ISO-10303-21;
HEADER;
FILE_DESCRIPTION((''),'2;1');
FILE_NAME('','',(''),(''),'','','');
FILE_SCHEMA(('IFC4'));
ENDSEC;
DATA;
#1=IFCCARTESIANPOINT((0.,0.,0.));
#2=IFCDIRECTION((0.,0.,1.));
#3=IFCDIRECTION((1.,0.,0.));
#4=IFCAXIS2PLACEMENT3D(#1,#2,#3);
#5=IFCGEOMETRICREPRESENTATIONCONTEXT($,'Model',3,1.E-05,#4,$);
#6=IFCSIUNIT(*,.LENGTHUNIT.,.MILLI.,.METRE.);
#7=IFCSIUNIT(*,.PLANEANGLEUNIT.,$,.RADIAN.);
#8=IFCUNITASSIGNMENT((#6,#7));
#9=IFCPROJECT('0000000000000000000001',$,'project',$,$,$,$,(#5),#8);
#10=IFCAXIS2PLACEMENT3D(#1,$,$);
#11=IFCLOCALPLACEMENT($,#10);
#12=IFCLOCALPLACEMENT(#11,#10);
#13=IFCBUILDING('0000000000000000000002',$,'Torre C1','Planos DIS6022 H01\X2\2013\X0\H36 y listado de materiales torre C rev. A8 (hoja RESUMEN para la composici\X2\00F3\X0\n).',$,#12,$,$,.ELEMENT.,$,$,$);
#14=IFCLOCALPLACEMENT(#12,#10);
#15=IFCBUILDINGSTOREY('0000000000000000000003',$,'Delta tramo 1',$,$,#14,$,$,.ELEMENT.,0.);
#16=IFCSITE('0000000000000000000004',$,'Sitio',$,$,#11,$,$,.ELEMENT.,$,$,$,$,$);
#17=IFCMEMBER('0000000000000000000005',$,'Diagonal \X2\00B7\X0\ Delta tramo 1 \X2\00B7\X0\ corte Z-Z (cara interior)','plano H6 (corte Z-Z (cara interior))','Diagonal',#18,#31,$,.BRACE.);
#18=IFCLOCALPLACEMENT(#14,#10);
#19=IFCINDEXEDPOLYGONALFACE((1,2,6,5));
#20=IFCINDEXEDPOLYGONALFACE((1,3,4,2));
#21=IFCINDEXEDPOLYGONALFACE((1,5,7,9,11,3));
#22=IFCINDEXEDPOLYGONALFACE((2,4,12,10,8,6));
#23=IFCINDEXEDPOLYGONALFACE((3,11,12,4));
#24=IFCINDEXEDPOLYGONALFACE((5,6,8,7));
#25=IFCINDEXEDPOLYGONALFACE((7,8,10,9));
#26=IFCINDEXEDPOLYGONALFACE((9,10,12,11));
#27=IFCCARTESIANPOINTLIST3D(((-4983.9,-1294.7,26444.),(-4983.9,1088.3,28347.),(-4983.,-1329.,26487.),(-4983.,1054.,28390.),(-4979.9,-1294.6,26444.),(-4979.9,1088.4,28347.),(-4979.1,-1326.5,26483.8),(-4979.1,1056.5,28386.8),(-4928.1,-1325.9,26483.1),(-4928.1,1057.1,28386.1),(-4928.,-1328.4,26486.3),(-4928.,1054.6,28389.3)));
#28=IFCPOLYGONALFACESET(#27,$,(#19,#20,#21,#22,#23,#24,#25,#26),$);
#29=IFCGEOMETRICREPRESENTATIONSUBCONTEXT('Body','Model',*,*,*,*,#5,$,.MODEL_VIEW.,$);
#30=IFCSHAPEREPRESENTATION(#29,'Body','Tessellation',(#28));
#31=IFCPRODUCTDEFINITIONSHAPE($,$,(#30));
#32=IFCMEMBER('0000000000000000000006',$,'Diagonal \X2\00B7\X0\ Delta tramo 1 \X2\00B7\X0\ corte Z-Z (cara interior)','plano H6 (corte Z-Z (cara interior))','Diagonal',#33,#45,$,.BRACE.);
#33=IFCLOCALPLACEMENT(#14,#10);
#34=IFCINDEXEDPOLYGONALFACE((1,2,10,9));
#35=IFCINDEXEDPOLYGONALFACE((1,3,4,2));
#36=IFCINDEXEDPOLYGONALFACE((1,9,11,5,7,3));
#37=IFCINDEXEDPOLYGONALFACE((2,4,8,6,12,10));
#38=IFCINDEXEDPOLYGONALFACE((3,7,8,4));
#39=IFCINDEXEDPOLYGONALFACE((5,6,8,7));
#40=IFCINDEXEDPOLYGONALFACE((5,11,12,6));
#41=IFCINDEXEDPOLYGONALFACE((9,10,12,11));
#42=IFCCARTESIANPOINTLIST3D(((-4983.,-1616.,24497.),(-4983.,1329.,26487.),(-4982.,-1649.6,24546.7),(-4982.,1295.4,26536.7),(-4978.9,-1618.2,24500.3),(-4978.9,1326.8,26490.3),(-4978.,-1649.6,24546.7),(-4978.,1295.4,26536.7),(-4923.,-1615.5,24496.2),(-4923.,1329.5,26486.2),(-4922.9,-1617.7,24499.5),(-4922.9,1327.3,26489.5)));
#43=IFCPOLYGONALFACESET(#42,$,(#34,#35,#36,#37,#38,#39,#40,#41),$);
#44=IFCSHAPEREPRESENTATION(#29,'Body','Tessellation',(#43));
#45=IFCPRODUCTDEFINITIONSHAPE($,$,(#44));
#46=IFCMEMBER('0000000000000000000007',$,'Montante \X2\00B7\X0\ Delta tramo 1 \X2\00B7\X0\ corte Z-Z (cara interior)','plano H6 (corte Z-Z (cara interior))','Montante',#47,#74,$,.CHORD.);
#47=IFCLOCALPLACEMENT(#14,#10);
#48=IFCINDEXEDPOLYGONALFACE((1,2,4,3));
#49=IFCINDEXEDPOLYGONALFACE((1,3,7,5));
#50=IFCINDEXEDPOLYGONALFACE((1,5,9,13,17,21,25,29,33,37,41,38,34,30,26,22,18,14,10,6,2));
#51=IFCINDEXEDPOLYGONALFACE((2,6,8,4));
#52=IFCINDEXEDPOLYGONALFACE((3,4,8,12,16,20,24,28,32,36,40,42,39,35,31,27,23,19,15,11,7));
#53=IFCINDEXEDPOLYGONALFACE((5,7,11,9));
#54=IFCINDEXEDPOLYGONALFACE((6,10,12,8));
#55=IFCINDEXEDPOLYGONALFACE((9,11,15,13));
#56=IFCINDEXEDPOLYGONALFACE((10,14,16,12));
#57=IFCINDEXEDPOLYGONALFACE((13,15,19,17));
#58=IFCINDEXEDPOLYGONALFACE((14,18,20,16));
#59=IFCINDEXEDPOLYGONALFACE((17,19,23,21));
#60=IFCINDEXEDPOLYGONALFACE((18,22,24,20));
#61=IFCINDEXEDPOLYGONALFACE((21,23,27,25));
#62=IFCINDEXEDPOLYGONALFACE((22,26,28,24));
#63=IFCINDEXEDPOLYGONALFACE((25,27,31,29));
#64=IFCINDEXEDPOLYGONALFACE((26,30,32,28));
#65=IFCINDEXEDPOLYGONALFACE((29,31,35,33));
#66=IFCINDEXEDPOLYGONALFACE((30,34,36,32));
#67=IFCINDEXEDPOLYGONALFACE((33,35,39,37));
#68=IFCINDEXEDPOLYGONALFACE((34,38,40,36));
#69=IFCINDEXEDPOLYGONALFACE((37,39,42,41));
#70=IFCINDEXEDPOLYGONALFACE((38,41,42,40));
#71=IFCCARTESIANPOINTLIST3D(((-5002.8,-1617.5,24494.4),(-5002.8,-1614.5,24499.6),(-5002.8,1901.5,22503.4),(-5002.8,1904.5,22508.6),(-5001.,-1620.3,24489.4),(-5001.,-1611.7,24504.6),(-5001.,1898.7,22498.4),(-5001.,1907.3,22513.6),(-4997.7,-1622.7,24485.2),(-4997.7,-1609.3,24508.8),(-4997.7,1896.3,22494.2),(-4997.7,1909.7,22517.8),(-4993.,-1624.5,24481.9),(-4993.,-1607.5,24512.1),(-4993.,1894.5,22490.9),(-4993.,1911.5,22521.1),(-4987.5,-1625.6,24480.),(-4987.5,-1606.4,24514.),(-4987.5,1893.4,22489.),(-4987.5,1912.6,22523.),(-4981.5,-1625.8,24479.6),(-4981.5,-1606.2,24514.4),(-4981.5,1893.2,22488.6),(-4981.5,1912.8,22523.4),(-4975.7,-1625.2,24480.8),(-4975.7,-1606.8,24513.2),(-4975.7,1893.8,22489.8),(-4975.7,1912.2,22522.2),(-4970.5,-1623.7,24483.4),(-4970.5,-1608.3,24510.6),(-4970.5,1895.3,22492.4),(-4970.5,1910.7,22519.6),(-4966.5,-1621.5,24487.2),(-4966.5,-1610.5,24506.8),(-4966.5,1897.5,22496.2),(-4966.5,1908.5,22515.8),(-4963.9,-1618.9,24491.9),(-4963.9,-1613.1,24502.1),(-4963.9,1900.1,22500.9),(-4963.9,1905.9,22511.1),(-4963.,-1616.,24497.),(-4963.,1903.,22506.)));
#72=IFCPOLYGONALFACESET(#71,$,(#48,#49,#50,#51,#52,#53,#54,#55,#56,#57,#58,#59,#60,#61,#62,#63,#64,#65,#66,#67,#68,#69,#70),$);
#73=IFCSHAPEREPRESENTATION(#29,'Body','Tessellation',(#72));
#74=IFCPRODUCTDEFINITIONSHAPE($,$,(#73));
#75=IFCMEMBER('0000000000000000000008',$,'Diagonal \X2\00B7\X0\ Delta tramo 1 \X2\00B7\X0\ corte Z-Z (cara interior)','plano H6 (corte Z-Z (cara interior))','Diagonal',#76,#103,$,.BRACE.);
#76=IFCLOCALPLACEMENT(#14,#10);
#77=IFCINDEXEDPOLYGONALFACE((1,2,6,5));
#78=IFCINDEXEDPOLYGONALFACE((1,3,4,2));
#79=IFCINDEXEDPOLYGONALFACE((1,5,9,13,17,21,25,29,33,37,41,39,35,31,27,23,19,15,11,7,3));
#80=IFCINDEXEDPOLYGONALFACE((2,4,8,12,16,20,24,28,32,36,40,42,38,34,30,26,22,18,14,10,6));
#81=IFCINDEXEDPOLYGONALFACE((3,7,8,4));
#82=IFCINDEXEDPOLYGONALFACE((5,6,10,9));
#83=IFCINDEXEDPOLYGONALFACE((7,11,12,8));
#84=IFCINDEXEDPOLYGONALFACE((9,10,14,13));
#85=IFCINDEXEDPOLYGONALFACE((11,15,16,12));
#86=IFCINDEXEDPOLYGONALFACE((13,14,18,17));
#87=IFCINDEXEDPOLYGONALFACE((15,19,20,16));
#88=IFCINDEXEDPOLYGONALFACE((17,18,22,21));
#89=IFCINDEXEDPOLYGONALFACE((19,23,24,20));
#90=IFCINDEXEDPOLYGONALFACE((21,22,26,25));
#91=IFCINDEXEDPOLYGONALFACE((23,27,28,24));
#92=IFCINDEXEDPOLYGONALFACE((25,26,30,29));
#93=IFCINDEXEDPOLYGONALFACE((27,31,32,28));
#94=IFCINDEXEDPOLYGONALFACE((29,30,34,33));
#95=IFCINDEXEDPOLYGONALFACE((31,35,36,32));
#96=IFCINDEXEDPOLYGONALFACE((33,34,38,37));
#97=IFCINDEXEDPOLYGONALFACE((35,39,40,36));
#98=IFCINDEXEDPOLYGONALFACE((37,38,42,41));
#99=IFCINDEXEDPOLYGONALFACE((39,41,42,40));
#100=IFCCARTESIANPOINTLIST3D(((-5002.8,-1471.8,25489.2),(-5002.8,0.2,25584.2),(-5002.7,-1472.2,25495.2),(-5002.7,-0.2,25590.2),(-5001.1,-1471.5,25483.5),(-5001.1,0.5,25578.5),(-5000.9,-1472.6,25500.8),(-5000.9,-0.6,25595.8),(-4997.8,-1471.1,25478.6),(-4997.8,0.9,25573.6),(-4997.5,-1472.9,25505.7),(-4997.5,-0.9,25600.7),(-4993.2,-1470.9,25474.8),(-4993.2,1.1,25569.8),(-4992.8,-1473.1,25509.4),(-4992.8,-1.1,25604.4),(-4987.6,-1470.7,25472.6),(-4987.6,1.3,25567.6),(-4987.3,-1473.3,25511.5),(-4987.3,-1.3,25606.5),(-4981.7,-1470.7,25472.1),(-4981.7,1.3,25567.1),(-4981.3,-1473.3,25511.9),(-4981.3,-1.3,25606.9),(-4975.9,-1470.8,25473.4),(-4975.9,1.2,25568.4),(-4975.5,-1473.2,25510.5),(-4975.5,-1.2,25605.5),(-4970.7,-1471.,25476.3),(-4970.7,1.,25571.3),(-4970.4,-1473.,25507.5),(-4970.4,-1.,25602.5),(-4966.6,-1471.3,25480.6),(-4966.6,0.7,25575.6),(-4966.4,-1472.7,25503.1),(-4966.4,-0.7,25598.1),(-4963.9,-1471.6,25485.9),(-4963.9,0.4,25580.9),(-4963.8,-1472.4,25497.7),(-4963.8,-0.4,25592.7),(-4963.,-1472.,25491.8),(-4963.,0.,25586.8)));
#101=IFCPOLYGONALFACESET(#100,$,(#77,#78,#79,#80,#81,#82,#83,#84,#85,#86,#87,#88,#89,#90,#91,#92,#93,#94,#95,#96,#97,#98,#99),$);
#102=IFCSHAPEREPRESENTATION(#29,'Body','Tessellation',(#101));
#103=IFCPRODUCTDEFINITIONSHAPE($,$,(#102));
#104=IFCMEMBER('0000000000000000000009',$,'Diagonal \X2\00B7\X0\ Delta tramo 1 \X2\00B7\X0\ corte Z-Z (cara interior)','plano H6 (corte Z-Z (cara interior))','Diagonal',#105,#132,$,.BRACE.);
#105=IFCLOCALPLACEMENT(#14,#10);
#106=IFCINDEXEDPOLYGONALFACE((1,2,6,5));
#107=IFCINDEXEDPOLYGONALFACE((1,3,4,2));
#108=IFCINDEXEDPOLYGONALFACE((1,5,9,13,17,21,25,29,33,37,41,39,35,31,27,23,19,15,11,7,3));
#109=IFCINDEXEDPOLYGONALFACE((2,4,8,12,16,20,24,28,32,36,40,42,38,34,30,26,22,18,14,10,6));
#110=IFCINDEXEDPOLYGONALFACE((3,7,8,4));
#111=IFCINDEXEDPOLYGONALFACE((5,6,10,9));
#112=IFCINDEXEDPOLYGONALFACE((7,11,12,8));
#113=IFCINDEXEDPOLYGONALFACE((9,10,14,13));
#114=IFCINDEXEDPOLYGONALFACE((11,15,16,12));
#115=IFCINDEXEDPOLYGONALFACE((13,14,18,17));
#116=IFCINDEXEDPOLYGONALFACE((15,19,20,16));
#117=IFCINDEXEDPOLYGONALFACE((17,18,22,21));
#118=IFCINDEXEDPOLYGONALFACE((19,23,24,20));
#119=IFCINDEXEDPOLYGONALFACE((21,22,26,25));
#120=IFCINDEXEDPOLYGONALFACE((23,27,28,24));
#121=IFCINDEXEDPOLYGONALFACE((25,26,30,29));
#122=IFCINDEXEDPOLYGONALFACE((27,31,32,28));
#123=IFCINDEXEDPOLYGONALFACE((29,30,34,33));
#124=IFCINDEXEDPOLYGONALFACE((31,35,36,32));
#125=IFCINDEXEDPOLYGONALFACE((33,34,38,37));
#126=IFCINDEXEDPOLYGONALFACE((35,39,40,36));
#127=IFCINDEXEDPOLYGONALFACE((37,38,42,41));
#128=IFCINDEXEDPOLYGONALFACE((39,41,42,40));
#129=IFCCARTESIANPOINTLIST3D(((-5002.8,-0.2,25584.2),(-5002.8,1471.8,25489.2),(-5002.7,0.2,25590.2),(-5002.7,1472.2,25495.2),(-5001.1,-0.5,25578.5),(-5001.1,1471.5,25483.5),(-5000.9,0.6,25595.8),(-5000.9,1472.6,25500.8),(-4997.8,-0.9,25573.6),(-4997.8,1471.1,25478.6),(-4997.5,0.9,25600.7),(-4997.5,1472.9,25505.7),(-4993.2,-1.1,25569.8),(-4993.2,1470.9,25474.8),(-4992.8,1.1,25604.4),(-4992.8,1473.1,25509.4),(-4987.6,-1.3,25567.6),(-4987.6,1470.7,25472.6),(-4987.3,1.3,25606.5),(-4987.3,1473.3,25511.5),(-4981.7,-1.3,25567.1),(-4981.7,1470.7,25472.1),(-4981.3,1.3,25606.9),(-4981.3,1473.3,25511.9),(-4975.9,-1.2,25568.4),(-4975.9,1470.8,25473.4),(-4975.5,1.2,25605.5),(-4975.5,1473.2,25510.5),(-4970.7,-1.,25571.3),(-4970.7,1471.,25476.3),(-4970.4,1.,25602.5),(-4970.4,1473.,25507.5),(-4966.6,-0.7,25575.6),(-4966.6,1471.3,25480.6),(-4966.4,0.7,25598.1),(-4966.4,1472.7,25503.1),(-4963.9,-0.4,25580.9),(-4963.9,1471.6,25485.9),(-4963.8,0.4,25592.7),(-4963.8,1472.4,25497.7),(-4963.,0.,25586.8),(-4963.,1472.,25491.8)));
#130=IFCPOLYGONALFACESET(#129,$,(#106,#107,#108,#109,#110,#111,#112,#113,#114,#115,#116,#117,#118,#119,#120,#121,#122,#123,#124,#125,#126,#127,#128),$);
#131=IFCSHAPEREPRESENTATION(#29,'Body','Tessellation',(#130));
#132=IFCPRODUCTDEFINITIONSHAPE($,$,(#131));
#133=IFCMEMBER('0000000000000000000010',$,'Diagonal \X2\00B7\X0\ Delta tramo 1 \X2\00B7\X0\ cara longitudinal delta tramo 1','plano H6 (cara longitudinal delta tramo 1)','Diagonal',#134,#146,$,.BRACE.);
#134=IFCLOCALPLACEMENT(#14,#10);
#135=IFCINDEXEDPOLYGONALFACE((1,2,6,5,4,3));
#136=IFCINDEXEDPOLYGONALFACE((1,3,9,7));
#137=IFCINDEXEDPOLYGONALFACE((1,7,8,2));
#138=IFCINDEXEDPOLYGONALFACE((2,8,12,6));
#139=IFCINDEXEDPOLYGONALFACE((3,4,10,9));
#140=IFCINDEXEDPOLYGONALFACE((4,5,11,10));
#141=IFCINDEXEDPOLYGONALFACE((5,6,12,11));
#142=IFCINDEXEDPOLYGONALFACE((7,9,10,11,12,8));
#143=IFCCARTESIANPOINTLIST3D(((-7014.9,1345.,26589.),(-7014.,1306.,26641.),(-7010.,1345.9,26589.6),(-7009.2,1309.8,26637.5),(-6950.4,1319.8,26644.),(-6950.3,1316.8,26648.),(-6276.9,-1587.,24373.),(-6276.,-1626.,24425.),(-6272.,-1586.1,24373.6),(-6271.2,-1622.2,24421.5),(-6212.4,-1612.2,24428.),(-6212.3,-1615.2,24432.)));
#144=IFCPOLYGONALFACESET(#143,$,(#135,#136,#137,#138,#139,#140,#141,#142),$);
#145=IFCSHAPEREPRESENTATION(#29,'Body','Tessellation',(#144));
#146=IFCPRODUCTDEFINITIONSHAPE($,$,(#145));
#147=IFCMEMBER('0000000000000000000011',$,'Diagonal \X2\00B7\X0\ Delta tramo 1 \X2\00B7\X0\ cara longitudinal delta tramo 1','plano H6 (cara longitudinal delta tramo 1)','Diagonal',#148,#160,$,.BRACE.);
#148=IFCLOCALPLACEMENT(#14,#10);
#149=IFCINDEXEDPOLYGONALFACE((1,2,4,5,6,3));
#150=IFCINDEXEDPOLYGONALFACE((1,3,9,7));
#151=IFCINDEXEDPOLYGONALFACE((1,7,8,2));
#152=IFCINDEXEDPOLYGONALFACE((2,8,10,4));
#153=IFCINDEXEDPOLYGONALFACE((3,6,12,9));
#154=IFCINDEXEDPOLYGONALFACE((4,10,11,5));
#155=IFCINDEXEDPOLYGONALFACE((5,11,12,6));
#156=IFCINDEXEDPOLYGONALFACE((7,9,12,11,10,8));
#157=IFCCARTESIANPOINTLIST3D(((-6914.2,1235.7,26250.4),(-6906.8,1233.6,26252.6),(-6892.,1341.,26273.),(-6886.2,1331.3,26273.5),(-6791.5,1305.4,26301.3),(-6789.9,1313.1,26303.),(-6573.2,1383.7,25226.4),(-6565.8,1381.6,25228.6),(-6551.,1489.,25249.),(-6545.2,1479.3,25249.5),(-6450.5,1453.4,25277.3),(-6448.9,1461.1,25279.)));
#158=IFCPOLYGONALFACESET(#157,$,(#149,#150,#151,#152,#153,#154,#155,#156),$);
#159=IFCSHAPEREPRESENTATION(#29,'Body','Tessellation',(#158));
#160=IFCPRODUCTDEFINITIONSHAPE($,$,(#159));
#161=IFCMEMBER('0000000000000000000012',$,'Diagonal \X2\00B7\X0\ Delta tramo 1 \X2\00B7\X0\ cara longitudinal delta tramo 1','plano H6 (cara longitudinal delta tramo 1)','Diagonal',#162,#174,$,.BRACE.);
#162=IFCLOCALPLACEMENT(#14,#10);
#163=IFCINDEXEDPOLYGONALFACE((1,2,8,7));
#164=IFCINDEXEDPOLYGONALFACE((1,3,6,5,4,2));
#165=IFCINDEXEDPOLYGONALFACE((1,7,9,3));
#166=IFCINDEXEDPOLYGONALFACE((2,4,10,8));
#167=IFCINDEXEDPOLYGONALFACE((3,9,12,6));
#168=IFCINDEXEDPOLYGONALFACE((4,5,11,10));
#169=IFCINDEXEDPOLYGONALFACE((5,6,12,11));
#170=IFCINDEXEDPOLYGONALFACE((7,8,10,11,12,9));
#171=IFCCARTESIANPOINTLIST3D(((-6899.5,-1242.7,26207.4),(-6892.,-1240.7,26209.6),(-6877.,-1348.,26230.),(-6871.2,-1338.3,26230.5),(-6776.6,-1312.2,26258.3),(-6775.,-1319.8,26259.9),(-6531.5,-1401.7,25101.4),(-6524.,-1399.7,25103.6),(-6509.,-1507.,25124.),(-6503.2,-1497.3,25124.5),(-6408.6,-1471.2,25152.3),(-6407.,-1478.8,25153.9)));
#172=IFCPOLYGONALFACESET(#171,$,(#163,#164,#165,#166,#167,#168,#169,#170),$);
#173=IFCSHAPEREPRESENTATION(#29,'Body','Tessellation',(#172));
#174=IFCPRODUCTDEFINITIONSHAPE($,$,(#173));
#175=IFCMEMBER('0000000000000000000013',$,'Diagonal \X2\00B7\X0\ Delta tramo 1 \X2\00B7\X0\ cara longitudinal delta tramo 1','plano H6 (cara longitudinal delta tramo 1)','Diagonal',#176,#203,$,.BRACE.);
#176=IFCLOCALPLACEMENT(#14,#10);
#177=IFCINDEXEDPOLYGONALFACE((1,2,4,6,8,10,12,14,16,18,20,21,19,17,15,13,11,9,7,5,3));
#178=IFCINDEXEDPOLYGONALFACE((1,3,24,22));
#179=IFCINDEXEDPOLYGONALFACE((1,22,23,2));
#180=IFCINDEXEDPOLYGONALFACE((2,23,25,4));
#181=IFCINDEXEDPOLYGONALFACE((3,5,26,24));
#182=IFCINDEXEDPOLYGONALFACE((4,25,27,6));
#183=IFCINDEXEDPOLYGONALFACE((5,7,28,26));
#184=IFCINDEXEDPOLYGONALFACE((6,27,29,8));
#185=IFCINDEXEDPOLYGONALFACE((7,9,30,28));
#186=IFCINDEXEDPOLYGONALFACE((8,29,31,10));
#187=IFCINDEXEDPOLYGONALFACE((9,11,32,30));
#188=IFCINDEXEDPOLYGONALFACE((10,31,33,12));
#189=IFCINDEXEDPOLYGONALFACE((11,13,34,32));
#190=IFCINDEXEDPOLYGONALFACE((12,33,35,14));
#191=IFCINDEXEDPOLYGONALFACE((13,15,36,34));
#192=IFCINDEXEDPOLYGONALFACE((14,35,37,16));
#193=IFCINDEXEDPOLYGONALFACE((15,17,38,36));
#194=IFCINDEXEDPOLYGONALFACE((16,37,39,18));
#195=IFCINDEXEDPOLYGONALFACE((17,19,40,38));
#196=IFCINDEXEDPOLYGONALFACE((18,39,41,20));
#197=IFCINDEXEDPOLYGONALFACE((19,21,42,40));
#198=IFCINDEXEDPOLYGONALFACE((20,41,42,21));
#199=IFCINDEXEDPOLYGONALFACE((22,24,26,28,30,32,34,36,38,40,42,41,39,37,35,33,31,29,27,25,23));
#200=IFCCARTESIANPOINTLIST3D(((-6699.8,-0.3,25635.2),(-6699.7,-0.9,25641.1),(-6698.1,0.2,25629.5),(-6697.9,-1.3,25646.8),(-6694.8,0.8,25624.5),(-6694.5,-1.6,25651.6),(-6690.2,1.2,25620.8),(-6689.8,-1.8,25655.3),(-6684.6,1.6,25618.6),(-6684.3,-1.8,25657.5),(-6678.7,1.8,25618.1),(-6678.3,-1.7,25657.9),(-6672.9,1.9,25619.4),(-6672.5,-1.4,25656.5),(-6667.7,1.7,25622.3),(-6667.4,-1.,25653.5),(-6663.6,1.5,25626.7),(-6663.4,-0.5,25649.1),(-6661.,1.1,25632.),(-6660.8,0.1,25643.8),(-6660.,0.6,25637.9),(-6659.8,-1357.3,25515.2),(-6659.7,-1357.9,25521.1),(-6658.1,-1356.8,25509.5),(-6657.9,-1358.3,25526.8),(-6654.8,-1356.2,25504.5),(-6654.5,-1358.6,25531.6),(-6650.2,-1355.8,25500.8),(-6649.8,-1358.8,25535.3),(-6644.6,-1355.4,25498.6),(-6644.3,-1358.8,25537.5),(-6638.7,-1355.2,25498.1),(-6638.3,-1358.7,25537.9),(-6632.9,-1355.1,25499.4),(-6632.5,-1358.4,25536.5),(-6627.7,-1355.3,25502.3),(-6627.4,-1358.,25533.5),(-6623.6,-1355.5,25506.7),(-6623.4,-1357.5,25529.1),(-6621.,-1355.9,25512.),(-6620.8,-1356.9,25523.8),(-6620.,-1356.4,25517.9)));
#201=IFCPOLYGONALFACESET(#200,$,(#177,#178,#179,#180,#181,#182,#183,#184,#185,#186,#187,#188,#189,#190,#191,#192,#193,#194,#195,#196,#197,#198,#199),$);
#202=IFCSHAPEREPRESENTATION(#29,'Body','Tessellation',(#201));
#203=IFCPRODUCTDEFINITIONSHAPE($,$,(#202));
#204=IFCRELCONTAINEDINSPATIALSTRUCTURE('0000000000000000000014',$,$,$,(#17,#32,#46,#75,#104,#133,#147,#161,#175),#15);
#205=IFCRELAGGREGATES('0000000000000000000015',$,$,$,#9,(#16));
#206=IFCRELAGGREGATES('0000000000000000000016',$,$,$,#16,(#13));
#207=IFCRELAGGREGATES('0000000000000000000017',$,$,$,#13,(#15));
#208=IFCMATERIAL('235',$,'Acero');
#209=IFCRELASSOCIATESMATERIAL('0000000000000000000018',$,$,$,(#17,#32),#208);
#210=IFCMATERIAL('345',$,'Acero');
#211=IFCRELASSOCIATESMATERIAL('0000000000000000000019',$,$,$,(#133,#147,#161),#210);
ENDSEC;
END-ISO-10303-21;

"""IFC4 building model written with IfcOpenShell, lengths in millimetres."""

from ifc_helpers import new_model, si_unit, frame, frame_2d, origin, origin_with_axes, place, context, subcontext, project, spatial, circle, l_section, extrude, material, element, save


model = new_model("IFC4")

# Units and contexts
model_context = context("Model", 3, precision=1e-05, world=origin_with_axes())
body_context = subcontext(model_context, "Body", "Model", "MODEL_VIEW")
ifc_project = project(units=[si_unit("LENGTHUNIT", "METRE", prefix="MILLI"), si_unit("PLANEANGLEUNIT", "RADIAN")], contexts=[model_context])

# Site, building, storey
site_placement = place(None, origin())
site = spatial("IfcSite", under=ifc_project, at=site_placement, Name="Sitio", CompositionType="ELEMENT")
building_placement = place(site_placement, origin())
building = spatial("IfcBuilding", under=site, at=building_placement, Name="Torre C1", Description="Planos DIS6022 H01–H36 y listado de materiales torre C rev. A8 (hoja RESUMEN para la composición).", CompositionType="ELEMENT")
storey_placement = place(building_placement, origin())
storey = spatial("IfcBuildingStorey", under=building, at=storey_placement, Name="Delta tramo 1", CompositionType="ELEMENT", Elevation=0.0)

# Members
ifc_material_1 = material(Name="345", Category="Acero")
ifc_material_2 = material(Name="235", Category="Acero")
member_1_placement = place(storey_placement, frame((-4983.0, -1329.0, 26487.0), z_axis=(0.0, 0.781412, 0.624015), x_axis=(0.999852, 0.010743, -0.013453)))
element("IfcMember", 1, at=member_1_placement, inside=storey, material=ifc_material_2, Name="Diagonal · Delta tramo 1 · corte Z-Z (cara interior)", Description="plano H6 (corte Z-Z (cara interior))", ObjectType="Diagonal", PredefinedType="BRACE", context=body_context, shape_type="SweptSolid", body=[
    extrude(l_section(Depth=55.0, Width=55.0, Thickness=4.0, at=frame_2d((27.5, 27.5))), None, (0.0, 0.0, 1.0), 3049.6),
])
member_2_placement = place(storey_placement, frame((-4983.0, 1329.0, 26487.0), z_axis=(0.0, -0.828571, -0.559884), x_axis=(0.99987, 0.009026, -0.013358)))
element("IfcMember", 2, at=member_2_placement, inside=storey, material=ifc_material_2, Name="Diagonal · Delta tramo 1 · corte Z-Z (cara interior)", Description="plano H6 (corte Z-Z (cara interior))", ObjectType="Diagonal", PredefinedType="BRACE", context=body_context, shape_type="SweptSolid", body=[
    extrude(l_section(Depth=60.0, Width=60.0, Thickness=4.0, at=frame_2d((30.0, 30.0))), None, (0.0, 0.0, 1.0), 3554.3),
])
member_3_placement = place(storey_placement, frame((-4983.0, -1616.0, 24497.0), z_axis=(0.0, 0.870351, -0.492432), x_axis=(1.0, 0.0, 0.0)))
element("IfcMember", 3, at=member_3_placement, inside=storey, Name="Montante · Delta tramo 1 · corte Z-Z (cara interior)", Description="plano H6 (corte Z-Z (cara interior))", ObjectType="Montante", PredefinedType="CHORD", context=body_context, shape_type="SweptSolid", body=[
    extrude(circle(Radius=20.0), None, (0.0, 0.0, 1.0), 4043.2),
])
for number, where, z_axis, x_axis, name in (
    (4, (-4983.0, -1472.0, 25492.0), (0.0, 0.997924, 0.064404), (0.999955, 0.000613, -0.009492), "Diagonal · Delta tramo 1 · corte Z-Z (cara interior)"),
    (5, (-4983.0, 1472.0, 25492.0), (0.0, -0.997924, 0.064404), (0.999955, -0.000613, -0.009492), "Diagonal · Delta tramo 1 · corte Z-Z (cara interior)"),
):
    element("IfcMember", number, at=place(storey_placement, frame(where, z_axis=z_axis, x_axis=x_axis)), inside=storey, Name=name, Description="plano H6 (corte Z-Z (cara interior))", ObjectType="Diagonal", PredefinedType="BRACE", context=body_context, shape_type="SweptSolid", body=[
        extrude(circle(Radius=20.0), None, (0.0, 0.0, 1.0), 1475.1),
    ])
member_4_placement = place(storey_placement, frame((-6276.0, -1626.0, 24425.0), z_axis=(-0.196874, 0.782161, 0.591156), x_axis=(0.980322, 0.165937, 0.106927)))
element("IfcMember", 6, at=member_4_placement, inside=storey, material=ifc_material_1, Name="Diagonal · Delta tramo 1 · cara longitudinal delta tramo 1", Description="plano H6 (cara longitudinal delta tramo 1)", ObjectType="Diagonal", PredefinedType="BRACE", context=body_context, shape_type="SweptSolid", body=[
    extrude(l_section(Depth=65.0, Width=65.0, Thickness=5.0, at=frame_2d((32.5, 32.5))), None, (0.0, 0.0, 1.0), 3748.6),
])
member_5_placement = place(storey_placement, frame((-6892.0, 1341.0, 26273.0), z_axis=(0.31302, 0.135856, -0.939979), x_axis=(0.928102, -0.253844, 0.272377)))
element("IfcMember", 7, at=member_5_placement, inside=storey, material=ifc_material_1, Name="Diagonal · Delta tramo 1 · cara longitudinal delta tramo 1", Description="plano H6 (cara longitudinal delta tramo 1)", ObjectType="Diagonal", PredefinedType="BRACE", context=body_context, shape_type="SweptSolid", body=[
    extrude(l_section(Depth=110.0, Width=110.0, Thickness=8.0, at=frame_2d((55.0, 55.0))), None, (0.0, 0.0, 1.0), 1089.4),
])
member_6_placement = place(storey_placement, frame((-6509.0, -1507.0, 25124.0), z_axis=(-0.312816, 0.135157, 0.940148), x_axis=(0.927617, 0.25621, 0.271813)))
element("IfcMember", 8, at=member_6_placement, inside=storey, material=ifc_material_1, Name="Diagonal · Delta tramo 1 · cara longitudinal delta tramo 1", Description="plano H6 (cara longitudinal delta tramo 1)", ObjectType="Diagonal", PredefinedType="BRACE", context=body_context, shape_type="SweptSolid", body=[
    extrude(l_section(Depth=110.0, Width=110.0, Thickness=8.0, at=frame_2d((55.0, 55.0))), None, (0.0, 0.0, 1.0), 1176.4),
])
for number, where, z_axis, x_axis, name in (
    (9, (-6680.0, 0.0, 25638.0), (0.02935, -0.995684, -0.088049), (0.999529, 0.030023, -0.006331), "Diagonal · Delta tramo 1 · cara longitudinal delta tramo 1"),
):
    element("IfcMember", number, at=place(storey_placement, frame(where, z_axis=z_axis, x_axis=x_axis)), inside=storey, Name=name, Description="plano H6 (cara longitudinal delta tramo 1)", ObjectType="Diagonal", PredefinedType="BRACE", context=body_context, shape_type="SweptSolid", body=[
        extrude(circle(Radius=20.0), None, (0.0, 0.0, 1.0), 1362.9),
    ])

save(model, "model.ifc")
